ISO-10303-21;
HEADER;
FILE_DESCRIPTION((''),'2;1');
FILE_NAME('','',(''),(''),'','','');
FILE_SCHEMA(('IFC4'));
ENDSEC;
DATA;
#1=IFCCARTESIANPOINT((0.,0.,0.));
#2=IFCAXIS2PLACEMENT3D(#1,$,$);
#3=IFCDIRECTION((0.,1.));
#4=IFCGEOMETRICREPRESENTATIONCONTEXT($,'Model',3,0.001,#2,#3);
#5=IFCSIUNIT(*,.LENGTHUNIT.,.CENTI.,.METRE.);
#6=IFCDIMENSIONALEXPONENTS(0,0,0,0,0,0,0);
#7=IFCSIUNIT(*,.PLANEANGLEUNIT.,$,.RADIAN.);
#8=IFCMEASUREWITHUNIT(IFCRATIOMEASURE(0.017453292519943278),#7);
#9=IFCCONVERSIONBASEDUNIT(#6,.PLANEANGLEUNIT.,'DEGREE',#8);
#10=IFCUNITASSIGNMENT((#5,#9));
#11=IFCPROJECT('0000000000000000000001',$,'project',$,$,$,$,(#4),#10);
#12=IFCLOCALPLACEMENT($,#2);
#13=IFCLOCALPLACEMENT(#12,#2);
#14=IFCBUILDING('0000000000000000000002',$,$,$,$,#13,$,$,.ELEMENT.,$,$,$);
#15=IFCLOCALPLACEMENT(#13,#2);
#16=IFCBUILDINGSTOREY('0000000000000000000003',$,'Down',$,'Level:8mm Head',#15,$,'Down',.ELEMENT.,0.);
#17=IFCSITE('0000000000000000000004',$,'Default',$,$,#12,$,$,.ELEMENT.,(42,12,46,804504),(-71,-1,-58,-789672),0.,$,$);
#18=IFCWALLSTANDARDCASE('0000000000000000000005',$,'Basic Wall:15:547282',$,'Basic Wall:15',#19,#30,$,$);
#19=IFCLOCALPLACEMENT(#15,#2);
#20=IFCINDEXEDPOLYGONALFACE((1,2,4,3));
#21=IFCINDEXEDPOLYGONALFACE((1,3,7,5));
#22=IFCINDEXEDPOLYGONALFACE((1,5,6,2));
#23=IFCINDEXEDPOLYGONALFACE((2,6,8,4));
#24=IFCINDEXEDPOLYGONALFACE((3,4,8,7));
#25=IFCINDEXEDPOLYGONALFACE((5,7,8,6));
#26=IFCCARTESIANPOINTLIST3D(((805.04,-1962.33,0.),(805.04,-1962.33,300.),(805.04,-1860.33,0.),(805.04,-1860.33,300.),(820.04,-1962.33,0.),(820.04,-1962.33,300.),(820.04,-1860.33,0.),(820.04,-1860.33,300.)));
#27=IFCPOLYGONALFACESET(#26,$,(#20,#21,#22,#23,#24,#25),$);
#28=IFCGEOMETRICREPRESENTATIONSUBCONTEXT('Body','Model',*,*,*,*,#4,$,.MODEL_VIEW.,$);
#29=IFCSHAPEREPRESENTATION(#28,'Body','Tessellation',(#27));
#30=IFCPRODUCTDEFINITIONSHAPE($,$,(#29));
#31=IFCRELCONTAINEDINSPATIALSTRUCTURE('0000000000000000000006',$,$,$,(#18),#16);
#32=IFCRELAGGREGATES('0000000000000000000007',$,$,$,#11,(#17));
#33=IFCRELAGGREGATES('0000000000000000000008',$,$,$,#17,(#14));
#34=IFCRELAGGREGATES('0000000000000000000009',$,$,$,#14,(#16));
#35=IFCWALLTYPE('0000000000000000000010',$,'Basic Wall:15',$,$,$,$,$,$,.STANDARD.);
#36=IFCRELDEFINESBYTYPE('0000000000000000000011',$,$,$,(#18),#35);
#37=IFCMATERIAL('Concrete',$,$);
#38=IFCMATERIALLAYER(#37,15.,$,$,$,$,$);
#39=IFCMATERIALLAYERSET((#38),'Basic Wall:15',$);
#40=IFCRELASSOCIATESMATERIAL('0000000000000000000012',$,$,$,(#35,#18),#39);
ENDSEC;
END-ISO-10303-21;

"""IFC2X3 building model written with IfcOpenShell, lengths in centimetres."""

from ifc_helpers import new_model, entity, si_unit, converted_unit, direction, frame, frame_2d, origin, place, context, subcontext, project, spatial, rectangle, extrude, material, layer, layer_set, layer_usage, type_object, element, save


model = new_model("IFC2X3")

# Units and contexts
model_context = context("Model", 3, precision=0.001, world=origin(), true_north=direction((0.0, 1.0)))
body_context = subcontext(model_context, "Body", "Model", "MODEL_VIEW")
ifc_project = project(units=[si_unit("LENGTHUNIT", "METRE", prefix="CENTI"), converted_unit("PLANEANGLEUNIT", "DEGREE", entity("IfcRatioMeasure", 0.017453292519943278), si_unit("PLANEANGLEUNIT", "RADIAN"), dimensions=[0, 0, 0, 0, 0, 0, 0])], contexts=[model_context])

# Site, building, storey
site_placement = place(None, origin())
site = spatial("IfcSite", under=ifc_project, at=site_placement, Name="Default", CompositionType="ELEMENT", RefLatitude=(42, 12, 46, 804504), RefLongitude=(-71, -1, -58, -789672), RefElevation=0.0)
building_placement = place(site_placement, origin())
building = spatial("IfcBuilding", under=site, at=building_placement, CompositionType="ELEMENT")
storey_placement = place(building_placement, origin())
storey = spatial("IfcBuildingStorey", under=building, at=storey_placement, Name="Down", ObjectType="Level:8mm Head", LongName="Down", CompositionType="ELEMENT", Elevation=0.0)

# Wall
ifc_material = material(Name="Concrete")
ifc_layer_1 = layer(ifc_material, 15.0)
ifc_layer_set_1 = layer_set([ifc_layer_1], Name="Basic Wall:15")
wall_type_1 = type_object("IfcWallType", Name="Basic Wall:15", PredefinedType="STANDARD", material=ifc_layer_set_1)
ifc_layer_usage_1 = layer_usage(ifc_layer_set_1, "AXIS2", "NEGATIVE", 7.5)
wall_1_placement = place(storey_placement, frame((812.54, -1962.33, 0.0), z_axis=(0.0, 0.0, 1.0), x_axis=(0.0, 1.0, 0.0)))
element("IfcWallStandardCase", 1, at=wall_1_placement, inside=storey, type_object=wall_type_1, material=ifc_layer_usage_1, Name="Basic Wall:15:547282", ObjectType="Basic Wall:15", context=body_context, shape_type="SweptSolid", body=[
    extrude(rectangle(XDim=101.99, YDim=15.0, at=frame_2d((51.0, 0.0), x_axis=(-1.0, 0.0))), origin(), (0.0, 0.0, 1.0), 300.0),
])

save(model, "model.ifc")
